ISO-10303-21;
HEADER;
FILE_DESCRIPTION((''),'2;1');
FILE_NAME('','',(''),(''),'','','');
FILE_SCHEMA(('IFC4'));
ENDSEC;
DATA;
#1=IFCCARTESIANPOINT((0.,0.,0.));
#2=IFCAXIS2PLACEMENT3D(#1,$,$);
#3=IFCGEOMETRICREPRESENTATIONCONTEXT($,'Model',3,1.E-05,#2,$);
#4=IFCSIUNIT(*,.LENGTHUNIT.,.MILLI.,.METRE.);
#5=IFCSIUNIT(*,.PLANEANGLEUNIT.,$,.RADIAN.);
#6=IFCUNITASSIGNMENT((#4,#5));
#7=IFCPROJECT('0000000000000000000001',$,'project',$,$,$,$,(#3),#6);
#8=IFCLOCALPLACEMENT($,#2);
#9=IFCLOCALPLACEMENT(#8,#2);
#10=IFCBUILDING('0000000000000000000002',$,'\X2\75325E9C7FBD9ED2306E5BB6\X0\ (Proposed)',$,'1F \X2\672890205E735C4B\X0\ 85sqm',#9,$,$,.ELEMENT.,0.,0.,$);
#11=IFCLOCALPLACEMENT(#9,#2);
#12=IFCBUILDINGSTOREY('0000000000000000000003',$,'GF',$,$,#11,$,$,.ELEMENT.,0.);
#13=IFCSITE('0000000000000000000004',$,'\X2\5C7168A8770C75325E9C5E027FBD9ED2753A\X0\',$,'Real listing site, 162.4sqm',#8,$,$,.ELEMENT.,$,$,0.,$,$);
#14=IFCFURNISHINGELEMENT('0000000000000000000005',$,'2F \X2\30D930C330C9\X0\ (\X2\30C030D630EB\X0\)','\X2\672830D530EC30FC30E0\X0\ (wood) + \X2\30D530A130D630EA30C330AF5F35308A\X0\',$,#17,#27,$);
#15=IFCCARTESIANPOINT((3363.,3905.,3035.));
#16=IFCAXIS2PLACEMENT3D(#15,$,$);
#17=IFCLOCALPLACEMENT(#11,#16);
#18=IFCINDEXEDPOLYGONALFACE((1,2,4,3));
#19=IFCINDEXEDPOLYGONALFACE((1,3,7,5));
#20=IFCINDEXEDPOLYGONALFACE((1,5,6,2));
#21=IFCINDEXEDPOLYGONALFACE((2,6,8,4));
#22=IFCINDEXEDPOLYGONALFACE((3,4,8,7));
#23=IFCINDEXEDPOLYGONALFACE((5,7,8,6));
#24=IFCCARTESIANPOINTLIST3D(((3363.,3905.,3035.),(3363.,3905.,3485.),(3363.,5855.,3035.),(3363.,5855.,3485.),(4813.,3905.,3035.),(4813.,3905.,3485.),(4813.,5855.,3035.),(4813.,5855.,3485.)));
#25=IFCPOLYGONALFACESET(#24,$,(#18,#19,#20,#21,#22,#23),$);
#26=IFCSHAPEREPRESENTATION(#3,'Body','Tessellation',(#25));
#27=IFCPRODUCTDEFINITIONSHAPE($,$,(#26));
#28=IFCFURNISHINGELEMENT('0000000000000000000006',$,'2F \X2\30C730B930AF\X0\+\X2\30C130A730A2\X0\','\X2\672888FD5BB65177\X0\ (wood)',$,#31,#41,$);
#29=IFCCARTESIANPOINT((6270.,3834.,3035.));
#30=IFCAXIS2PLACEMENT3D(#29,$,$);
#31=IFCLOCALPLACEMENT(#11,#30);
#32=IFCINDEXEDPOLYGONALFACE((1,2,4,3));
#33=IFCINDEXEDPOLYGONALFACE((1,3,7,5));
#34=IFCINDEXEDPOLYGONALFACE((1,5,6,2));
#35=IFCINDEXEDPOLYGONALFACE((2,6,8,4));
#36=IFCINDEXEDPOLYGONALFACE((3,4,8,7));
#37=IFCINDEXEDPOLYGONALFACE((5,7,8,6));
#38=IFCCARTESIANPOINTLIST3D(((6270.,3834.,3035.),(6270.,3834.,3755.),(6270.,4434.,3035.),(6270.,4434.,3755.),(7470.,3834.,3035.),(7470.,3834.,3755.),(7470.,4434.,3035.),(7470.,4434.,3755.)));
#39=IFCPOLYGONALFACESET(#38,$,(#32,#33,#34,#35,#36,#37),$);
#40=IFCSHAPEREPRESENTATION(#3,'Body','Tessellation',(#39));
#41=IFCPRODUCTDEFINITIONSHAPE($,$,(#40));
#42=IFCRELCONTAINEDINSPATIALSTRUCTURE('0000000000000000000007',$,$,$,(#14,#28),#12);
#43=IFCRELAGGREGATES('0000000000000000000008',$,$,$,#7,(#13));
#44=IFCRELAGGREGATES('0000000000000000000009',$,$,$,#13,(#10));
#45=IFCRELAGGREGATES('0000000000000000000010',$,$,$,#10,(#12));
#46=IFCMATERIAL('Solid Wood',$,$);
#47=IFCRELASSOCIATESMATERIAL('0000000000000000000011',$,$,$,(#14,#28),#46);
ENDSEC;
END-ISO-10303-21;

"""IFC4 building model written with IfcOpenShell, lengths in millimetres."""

from ifc_helpers import new_model, si_unit, frame, frame_2d, origin, place, context, project, spatial, rectangle, extrude, material, element, save


model = new_model("IFC4")

# Units and contexts
model_context = context("Model", 3, precision=1e-05, world=origin())
ifc_project = project(units=[si_unit("LENGTHUNIT", "METRE", prefix="MILLI"), si_unit("PLANEANGLEUNIT", "RADIAN")], contexts=[model_context])

# Site, building, storey
site_placement = place(None, origin())
site = spatial("IfcSite", under=ifc_project, at=site_placement, Name="山梨県甲府市羽黒町", ObjectType="Real listing site, 162.4sqm", CompositionType="ELEMENT", RefElevation=0.0)
building_placement = place(site_placement, origin())
building = spatial("IfcBuilding", under=site, at=building_placement, Name="甲府羽黒の家 (Proposed)", ObjectType="1F 木造平屋 85sqm", CompositionType="ELEMENT", ElevationOfRefHeight=0.0, ElevationOfTerrain=0.0)
storey_placement = place(building_placement, origin())
storey = spatial("IfcBuildingStorey", under=building, at=storey_placement, Name="GF", CompositionType="ELEMENT", Elevation=0.0)

# Shared definitions
ifc_material_1 = material(Name="Solid Wood")

# Furnishing elements
furnishing_1_placement = place(storey_placement, frame((3363.0, 3905.0, 3035.0)))
element("IfcFurnishingElement", 1, at=furnishing_1_placement, inside=storey, material=ifc_material_1, Name="2F ベッド (ダブル)", Description="木フレーム (wood) + ファブリック張り", context=model_context, shape_type="SweptSolid", body=[
    extrude(rectangle(XDim=1450.0, YDim=1950.0, at=frame_2d((725.0, 975.0))), frame((3363.0, 3905.0, 3035.0)), (0.0, 0.0, 1.0), 450.0),
])
furnishing_2_placement = place(storey_placement, frame((6270.0, 3834.0, 3035.0)))
element("IfcFurnishingElement", 2, at=furnishing_2_placement, inside=storey, material=ifc_material_1, Name="2F デスク+チェア", Description="木製家具 (wood)", context=model_context, shape_type="SweptSolid", body=[
    extrude(rectangle(XDim=1200.0, YDim=600.0, at=frame_2d((600.0, 300.0))), frame((6270.0, 3834.0, 3035.0)), (0.0, 0.0, 1.0), 720.0),
])

save(model, "model.ifc")
